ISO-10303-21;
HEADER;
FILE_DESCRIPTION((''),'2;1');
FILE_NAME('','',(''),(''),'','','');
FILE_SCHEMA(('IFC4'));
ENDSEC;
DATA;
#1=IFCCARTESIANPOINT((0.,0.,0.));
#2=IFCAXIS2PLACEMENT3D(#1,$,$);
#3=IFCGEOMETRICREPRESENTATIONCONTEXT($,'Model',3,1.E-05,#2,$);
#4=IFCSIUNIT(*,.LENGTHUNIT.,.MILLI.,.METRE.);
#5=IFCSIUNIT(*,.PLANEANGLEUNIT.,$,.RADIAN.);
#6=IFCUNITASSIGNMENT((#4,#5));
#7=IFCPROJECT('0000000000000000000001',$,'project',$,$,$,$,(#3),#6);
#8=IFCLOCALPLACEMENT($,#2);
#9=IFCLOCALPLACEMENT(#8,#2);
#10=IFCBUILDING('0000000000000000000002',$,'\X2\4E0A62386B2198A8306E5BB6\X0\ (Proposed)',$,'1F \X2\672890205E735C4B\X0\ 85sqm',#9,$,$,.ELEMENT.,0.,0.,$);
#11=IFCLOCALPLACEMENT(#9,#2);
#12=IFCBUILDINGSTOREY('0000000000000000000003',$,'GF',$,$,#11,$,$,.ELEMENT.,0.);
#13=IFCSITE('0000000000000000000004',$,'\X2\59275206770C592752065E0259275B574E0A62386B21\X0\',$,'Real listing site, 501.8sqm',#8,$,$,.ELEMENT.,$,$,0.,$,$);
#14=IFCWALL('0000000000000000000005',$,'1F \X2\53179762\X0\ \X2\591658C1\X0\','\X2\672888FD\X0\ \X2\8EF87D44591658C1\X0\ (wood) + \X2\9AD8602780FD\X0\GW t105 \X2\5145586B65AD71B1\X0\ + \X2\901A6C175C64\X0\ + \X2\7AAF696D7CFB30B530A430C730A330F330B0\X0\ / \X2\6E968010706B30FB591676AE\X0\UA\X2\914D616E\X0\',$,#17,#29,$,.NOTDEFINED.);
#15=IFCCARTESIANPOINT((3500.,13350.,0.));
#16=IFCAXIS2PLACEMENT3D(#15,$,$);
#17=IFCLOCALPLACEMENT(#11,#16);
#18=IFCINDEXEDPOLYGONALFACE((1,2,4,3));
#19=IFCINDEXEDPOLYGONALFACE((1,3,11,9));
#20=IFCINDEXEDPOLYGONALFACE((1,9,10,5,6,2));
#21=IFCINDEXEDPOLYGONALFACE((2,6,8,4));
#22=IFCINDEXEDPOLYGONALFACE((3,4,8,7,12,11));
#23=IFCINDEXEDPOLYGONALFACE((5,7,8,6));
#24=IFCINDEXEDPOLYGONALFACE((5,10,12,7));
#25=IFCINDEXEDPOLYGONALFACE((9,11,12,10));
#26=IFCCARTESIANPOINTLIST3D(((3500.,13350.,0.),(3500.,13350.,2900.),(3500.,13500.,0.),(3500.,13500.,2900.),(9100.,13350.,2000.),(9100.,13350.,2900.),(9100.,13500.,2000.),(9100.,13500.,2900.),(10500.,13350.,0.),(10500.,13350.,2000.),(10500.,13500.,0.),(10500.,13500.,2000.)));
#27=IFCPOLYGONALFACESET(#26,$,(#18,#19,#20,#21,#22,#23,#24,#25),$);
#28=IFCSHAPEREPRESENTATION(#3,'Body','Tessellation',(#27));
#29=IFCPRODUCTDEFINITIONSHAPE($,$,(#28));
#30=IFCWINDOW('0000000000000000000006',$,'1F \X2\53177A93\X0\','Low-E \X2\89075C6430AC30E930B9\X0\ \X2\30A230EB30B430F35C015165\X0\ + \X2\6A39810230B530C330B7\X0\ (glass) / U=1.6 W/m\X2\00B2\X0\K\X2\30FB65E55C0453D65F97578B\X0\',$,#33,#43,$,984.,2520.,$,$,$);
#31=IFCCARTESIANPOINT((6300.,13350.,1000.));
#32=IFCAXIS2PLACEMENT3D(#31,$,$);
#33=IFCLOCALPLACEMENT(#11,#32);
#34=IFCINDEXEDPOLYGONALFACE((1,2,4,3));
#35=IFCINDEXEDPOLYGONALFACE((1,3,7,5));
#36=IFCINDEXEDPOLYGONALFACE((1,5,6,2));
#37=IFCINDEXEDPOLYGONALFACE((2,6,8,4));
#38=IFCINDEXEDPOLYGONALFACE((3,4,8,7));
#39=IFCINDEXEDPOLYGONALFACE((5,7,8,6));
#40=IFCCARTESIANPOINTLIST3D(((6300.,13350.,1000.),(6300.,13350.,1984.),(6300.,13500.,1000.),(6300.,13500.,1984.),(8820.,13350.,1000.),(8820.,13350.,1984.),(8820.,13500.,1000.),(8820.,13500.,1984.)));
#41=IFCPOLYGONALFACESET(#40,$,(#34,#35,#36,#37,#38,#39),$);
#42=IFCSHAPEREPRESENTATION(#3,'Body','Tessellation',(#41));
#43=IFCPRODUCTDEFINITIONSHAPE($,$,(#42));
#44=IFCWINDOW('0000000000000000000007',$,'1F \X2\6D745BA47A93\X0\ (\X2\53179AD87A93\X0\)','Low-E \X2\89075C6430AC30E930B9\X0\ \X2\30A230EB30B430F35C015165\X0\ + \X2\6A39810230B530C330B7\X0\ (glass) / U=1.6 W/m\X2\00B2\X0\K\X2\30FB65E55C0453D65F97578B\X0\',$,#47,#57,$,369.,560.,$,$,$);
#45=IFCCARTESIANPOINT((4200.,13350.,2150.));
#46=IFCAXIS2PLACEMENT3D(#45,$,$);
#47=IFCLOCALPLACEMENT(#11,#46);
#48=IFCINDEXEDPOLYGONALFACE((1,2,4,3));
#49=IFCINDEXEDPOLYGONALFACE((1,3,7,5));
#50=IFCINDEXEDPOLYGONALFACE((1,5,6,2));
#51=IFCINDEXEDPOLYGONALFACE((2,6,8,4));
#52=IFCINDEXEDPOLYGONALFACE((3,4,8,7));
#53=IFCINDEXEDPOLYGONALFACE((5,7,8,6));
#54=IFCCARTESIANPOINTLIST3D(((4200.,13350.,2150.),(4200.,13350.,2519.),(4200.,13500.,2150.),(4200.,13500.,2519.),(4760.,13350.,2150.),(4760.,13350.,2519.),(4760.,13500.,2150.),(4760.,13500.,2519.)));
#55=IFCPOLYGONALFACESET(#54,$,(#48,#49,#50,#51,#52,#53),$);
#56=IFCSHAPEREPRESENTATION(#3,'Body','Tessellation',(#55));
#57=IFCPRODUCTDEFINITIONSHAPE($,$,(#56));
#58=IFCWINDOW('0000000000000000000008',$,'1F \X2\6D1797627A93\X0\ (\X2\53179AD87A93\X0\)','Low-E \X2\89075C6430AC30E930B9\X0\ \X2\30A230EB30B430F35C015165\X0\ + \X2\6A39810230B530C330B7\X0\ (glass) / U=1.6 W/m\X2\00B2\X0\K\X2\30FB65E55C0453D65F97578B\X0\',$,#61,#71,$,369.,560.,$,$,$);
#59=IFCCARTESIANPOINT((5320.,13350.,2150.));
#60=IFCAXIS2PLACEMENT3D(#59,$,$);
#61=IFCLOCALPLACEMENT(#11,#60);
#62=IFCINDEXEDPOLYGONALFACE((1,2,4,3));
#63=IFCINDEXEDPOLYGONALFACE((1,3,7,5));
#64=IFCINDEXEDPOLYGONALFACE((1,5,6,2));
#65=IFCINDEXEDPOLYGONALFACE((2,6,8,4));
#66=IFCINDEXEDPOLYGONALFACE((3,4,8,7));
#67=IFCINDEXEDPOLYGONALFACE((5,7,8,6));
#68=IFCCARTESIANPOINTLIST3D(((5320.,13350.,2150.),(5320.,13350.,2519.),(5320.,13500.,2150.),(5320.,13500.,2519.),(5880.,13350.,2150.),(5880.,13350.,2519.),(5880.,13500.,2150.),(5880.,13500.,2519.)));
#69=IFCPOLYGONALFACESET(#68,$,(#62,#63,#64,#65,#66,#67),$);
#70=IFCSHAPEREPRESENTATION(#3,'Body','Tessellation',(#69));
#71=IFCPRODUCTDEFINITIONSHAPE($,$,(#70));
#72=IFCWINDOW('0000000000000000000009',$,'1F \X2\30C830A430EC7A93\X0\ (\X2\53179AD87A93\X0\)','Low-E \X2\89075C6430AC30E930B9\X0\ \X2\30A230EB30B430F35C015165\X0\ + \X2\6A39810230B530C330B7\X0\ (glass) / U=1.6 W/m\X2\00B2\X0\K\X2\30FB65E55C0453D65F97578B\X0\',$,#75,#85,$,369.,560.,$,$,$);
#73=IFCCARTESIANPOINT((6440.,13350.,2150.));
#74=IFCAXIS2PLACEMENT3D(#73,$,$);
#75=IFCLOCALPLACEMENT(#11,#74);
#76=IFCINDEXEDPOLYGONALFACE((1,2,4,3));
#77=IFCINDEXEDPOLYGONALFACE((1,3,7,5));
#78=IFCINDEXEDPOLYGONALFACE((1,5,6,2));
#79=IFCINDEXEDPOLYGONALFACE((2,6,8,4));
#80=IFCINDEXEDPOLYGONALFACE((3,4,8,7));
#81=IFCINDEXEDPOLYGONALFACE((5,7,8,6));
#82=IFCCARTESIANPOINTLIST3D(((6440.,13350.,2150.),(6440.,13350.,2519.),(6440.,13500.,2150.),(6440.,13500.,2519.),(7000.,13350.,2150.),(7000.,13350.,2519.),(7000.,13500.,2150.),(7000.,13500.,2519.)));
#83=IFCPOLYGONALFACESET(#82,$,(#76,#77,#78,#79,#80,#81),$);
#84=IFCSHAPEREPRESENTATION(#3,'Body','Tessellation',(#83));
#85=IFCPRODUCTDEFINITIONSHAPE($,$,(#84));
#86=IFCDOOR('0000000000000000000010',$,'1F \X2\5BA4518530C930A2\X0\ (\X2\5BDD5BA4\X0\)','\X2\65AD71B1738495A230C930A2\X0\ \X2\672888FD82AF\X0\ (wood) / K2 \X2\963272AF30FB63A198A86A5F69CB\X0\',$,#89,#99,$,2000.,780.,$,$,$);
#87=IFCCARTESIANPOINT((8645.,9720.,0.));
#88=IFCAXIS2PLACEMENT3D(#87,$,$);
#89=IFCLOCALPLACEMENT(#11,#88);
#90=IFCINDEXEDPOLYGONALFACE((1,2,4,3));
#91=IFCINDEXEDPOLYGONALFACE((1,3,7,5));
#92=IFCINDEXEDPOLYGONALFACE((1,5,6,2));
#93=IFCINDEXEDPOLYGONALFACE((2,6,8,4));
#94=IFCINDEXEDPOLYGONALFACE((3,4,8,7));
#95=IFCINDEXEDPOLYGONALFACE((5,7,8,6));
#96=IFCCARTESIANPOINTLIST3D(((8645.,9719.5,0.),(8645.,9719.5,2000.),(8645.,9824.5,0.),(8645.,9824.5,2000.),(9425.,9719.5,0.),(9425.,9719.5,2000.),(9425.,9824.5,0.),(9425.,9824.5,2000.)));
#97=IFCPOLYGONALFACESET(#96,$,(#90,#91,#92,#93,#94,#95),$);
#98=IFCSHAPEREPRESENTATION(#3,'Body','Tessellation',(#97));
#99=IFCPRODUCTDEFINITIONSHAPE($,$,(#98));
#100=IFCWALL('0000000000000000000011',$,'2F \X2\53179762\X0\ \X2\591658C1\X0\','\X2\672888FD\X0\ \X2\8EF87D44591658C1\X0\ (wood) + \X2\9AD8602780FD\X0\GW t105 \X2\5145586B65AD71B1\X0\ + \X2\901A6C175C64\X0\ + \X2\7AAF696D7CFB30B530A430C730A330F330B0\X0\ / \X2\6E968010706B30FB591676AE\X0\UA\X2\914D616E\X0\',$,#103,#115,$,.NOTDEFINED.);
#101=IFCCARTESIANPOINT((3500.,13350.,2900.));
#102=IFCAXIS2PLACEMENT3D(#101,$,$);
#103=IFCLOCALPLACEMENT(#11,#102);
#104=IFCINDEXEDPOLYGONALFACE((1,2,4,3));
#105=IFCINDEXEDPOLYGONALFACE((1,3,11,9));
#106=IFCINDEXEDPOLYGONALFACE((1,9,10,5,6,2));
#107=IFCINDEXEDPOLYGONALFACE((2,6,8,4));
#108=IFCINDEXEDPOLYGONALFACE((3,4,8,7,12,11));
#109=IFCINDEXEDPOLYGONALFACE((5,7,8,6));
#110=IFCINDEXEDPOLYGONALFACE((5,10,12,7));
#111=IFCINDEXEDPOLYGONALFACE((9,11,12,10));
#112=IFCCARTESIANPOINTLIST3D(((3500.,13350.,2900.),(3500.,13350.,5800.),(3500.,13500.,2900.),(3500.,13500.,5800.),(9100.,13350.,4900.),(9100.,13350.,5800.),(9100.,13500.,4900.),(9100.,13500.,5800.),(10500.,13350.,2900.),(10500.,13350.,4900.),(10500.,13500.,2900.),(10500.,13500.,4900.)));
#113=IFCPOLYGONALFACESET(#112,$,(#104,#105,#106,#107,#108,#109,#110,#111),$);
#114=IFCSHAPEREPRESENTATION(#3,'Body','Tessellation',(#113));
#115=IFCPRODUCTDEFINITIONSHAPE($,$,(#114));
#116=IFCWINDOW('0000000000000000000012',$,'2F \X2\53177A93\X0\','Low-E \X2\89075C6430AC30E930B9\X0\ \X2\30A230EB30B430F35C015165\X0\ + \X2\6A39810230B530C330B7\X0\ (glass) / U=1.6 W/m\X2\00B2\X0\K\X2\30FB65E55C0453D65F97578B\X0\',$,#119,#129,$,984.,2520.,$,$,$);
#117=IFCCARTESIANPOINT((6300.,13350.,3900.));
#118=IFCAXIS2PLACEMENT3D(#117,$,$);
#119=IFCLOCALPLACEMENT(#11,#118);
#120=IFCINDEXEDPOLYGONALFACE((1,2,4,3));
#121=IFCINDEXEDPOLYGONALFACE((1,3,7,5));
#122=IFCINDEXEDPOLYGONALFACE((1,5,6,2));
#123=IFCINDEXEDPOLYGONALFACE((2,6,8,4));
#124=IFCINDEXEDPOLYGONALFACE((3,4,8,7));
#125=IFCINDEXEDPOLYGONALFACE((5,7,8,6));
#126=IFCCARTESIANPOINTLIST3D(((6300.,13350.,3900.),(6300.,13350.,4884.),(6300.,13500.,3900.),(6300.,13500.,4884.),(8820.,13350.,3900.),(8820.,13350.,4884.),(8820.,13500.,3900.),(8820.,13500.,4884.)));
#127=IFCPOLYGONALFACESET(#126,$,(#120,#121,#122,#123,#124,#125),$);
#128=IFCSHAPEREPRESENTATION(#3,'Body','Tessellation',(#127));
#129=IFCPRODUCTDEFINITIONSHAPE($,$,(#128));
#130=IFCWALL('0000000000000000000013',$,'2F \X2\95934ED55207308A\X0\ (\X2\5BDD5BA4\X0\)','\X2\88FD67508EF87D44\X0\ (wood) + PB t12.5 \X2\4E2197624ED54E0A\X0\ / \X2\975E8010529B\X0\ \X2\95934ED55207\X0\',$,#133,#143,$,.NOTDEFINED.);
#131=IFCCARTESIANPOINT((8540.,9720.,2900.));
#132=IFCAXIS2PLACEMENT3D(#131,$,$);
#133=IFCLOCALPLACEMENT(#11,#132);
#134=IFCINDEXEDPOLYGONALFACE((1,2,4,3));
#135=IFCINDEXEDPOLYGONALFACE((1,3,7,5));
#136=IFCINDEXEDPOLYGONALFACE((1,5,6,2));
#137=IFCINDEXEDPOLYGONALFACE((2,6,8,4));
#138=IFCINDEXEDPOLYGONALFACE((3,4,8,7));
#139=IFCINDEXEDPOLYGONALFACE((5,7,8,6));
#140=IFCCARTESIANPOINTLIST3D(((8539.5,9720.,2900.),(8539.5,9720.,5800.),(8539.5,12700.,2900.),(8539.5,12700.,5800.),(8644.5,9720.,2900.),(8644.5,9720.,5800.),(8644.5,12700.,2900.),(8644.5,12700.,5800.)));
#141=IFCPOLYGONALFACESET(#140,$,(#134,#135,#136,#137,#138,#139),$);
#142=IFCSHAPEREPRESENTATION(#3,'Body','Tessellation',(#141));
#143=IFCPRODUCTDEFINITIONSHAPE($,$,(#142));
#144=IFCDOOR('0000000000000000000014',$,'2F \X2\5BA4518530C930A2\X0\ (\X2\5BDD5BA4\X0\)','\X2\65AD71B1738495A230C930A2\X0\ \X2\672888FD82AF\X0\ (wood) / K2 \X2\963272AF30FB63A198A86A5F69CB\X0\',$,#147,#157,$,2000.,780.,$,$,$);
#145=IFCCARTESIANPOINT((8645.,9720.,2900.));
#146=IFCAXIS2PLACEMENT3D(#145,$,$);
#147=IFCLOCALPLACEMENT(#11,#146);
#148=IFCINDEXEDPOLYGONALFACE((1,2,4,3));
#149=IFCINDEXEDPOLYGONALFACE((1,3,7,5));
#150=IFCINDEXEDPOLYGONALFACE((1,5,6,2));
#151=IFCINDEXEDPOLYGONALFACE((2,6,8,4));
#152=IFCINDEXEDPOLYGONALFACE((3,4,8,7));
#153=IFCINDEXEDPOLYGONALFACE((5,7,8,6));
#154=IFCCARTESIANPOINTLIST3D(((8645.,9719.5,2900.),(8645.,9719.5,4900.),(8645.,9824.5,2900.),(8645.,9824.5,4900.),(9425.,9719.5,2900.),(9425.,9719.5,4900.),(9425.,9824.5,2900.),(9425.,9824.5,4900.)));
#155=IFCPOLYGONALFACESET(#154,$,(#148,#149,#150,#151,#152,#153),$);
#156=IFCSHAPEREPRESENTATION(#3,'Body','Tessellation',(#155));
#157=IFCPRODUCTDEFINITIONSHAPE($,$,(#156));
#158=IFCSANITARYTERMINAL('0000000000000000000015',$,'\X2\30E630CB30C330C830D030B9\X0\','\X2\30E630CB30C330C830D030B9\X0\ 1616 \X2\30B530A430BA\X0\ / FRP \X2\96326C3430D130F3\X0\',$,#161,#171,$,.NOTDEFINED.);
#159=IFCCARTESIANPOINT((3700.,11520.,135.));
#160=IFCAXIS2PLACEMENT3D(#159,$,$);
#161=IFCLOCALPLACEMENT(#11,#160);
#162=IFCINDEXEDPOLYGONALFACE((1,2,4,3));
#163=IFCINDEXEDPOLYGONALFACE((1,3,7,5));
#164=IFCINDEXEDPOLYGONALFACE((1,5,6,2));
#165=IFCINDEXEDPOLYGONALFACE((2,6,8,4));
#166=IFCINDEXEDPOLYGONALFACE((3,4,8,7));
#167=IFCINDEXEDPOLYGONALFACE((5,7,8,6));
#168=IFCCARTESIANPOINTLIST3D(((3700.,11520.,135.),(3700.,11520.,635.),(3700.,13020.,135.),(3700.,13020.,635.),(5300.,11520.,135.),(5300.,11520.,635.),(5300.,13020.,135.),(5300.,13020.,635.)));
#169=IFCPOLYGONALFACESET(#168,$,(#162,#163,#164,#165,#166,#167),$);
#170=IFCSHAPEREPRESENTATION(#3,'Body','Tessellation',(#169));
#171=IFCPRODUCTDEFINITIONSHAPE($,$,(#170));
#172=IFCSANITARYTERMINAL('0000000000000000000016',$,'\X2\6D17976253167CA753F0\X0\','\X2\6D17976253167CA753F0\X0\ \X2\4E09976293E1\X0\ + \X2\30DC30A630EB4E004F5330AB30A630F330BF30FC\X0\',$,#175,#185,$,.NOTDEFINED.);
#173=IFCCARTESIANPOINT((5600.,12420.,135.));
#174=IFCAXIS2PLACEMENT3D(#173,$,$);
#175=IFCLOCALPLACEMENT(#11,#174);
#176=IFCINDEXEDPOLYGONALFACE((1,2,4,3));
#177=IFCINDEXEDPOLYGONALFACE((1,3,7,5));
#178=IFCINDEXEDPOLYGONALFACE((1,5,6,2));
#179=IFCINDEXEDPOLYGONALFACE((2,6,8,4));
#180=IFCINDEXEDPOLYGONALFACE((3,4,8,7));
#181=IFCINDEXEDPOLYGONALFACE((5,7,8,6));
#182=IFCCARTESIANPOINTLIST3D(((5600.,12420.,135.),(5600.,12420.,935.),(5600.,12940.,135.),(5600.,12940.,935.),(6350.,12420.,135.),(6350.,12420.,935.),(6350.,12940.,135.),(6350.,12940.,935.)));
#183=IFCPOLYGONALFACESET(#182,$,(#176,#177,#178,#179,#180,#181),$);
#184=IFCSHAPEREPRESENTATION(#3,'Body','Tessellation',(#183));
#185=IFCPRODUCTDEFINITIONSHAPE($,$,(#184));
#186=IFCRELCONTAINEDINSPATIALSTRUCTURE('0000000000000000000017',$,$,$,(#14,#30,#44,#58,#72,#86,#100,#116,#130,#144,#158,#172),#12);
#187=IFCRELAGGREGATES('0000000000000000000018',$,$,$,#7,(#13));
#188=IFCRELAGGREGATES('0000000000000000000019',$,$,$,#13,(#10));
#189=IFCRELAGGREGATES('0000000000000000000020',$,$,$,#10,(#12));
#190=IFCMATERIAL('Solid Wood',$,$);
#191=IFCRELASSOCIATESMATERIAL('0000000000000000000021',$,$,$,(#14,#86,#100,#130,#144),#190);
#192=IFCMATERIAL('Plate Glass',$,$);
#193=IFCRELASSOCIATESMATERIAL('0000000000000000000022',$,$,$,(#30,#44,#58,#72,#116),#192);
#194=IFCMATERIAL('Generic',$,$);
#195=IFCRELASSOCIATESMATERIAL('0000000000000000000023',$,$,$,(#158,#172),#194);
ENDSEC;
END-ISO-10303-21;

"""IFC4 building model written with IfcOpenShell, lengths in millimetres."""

from ifc_helpers import new_model, si_unit, frame, frame_2d, origin, place, context, project, spatial, rectangle, extrude, material, element, fill, save


model = new_model("IFC4")

# Units and contexts
model_context = context("Model", 3, precision=1e-05, world=origin())
ifc_project = project(units=[si_unit("LENGTHUNIT", "METRE", prefix="MILLI"), si_unit("PLANEANGLEUNIT", "RADIAN")], contexts=[model_context])

# Site, building, storey
site_placement = place(None, origin())
site = spatial("IfcSite", under=ifc_project, at=site_placement, Name="大分県大分市大字上戸次", ObjectType="Real listing site, 501.8sqm", CompositionType="ELEMENT", RefElevation=0.0)
building_placement = place(site_placement, origin())
building = spatial("IfcBuilding", under=site, at=building_placement, Name="上戸次風の家 (Proposed)", ObjectType="1F 木造平屋 85sqm", CompositionType="ELEMENT", ElevationOfRefHeight=0.0, ElevationOfTerrain=0.0)
storey_placement = place(building_placement, origin())
storey = spatial("IfcBuildingStorey", under=building, at=storey_placement, Name="GF", CompositionType="ELEMENT", Elevation=0.0)

# Wall, openings, windows
ifc_material_1 = material(Name="Solid Wood")
wall_1_placement = place(storey_placement, frame((3500.0, 13350.0, 0.0)))
wall_1 = element("IfcWall", 1, at=wall_1_placement, inside=storey, material=ifc_material_1, Name="1F 北面 外壁", Description="木製 軸組外壁 (wood) + 高性能GW t105 充填断熱 + 通気層 + 窯業系サイディング / 準耐火・外皮UA配慮", PredefinedType="NOTDEFINED", context=model_context, shape_type="SweptSolid", body=[
    extrude(rectangle(XDim=7000.0, YDim=150.0, at=frame_2d((3500.0, 75.0))), frame((3500.0, 13350.0, 0.0)), (0.0, 0.0, 1.0), 2900.0),
])
opening_1_placement = place(storey_placement, frame((6300.0, 13350.0, 1000.0)))
opening_1 = element("IfcOpeningElement", 2, at=opening_1_placement, cuts=wall_1, PredefinedType="NOTDEFINED", context=model_context, shape_type="SweptSolid", body=[
    extrude(rectangle(XDim=2520.0, YDim=150.0, at=frame_2d((1260.0, 75.0))), frame((6300.0, 13350.0, 1000.0)), (0.0, 0.0, 1.0), 984.0),
])
opening_2_placement = place(storey_placement, frame((4200.0, 13350.0, 2150.0)))
opening_2 = element("IfcOpeningElement", 3, at=opening_2_placement, cuts=wall_1, PredefinedType="NOTDEFINED", context=model_context, shape_type="SweptSolid", body=[
    extrude(rectangle(XDim=560.0, YDim=150.0, at=frame_2d((280.0, 75.0))), frame((4200.0, 13350.0, 2150.0)), (0.0, 0.0, 1.0), 369.0),
])
opening_3_placement = place(storey_placement, frame((5320.0, 13350.0, 2150.0)))
opening_3 = element("IfcOpeningElement", 4, at=opening_3_placement, cuts=wall_1, PredefinedType="NOTDEFINED", context=model_context, shape_type="SweptSolid", body=[
    extrude(rectangle(XDim=560.0, YDim=150.0, at=frame_2d((280.0, 75.0))), frame((5320.0, 13350.0, 2150.0)), (0.0, 0.0, 1.0), 369.0),
])
opening_4_placement = place(storey_placement, frame((6440.0, 13350.0, 2150.0)))
opening_4 = element("IfcOpeningElement", 5, at=opening_4_placement, cuts=wall_1, PredefinedType="NOTDEFINED", context=model_context, shape_type="SweptSolid", body=[
    extrude(rectangle(XDim=560.0, YDim=150.0, at=frame_2d((280.0, 75.0))), frame((6440.0, 13350.0, 2150.0)), (0.0, 0.0, 1.0), 369.0),
])
ifc_material_2 = material(Name="Plate Glass")
window_1_placement = place(storey_placement, frame((6300.0, 13350.0, 1000.0)))
window_1 = element("IfcWindow", 6, at=window_1_placement, inside=storey, material=ifc_material_2, Name="1F 北窓", Description="Low-E 複層ガラス アルゴン封入 + 樹脂サッシ (glass) / U=1.6 W/m²K・日射取得型", OverallHeight=984.0, OverallWidth=2520.0, context=model_context, shape_type="SweptSolid", body=[
    extrude(rectangle(XDim=2520.0, YDim=150.0, at=frame_2d((1260.0, 75.0))), frame((6300.0, 13350.0, 1000.0)), (0.0, 0.0, 1.0), 984.0),
])
fill(opening_1, window_1)
window_2_placement = place(storey_placement, frame((4200.0, 13350.0, 2150.0)))
window_2 = element("IfcWindow", 7, at=window_2_placement, inside=storey, material=ifc_material_2, Name="1F 浴室窓 (北高窓)", Description="Low-E 複層ガラス アルゴン封入 + 樹脂サッシ (glass) / U=1.6 W/m²K・日射取得型", OverallHeight=369.0, OverallWidth=560.0, context=model_context, shape_type="SweptSolid", body=[
    extrude(rectangle(XDim=560.0, YDim=150.0, at=frame_2d((280.0, 75.0))), frame((4200.0, 13350.0, 2150.0)), (0.0, 0.0, 1.0), 369.0),
])
fill(opening_2, window_2)
window_3_placement = place(storey_placement, frame((5320.0, 13350.0, 2150.0)))
window_3 = element("IfcWindow", 8, at=window_3_placement, inside=storey, material=ifc_material_2, Name="1F 洗面窓 (北高窓)", Description="Low-E 複層ガラス アルゴン封入 + 樹脂サッシ (glass) / U=1.6 W/m²K・日射取得型", OverallHeight=369.0, OverallWidth=560.0, context=model_context, shape_type="SweptSolid", body=[
    extrude(rectangle(XDim=560.0, YDim=150.0, at=frame_2d((280.0, 75.0))), frame((5320.0, 13350.0, 2150.0)), (0.0, 0.0, 1.0), 369.0),
])
fill(opening_3, window_3)
window_4_placement = place(storey_placement, frame((6440.0, 13350.0, 2150.0)))
window_4 = element("IfcWindow", 9, at=window_4_placement, inside=storey, material=ifc_material_2, Name="1F トイレ窓 (北高窓)", Description="Low-E 複層ガラス アルゴン封入 + 樹脂サッシ (glass) / U=1.6 W/m²K・日射取得型", OverallHeight=369.0, OverallWidth=560.0, context=model_context, shape_type="SweptSolid", body=[
    extrude(rectangle(XDim=560.0, YDim=150.0, at=frame_2d((280.0, 75.0))), frame((6440.0, 13350.0, 2150.0)), (0.0, 0.0, 1.0), 369.0),
])
fill(opening_4, window_4)

# Door
door_1_placement = place(storey_placement, frame((8645.0, 9720.0, 0.0)))
element("IfcDoor", 10, at=door_1_placement, inside=storey, material=ifc_material_1, Name="1F 室内ドア (寝室)", Description="断熱玄関ドア 木製芯 (wood) / K2 防犯・採風機構", OverallHeight=2000.0, OverallWidth=780.0, context=model_context, shape_type="SweptSolid", body=[
    extrude(rectangle(XDim=780.0, YDim=105.0, at=frame_2d((390.0, 52.0))), frame((8645.0, 9720.0, 0.0)), (0.0, 0.0, 1.0), 2000.0),
])

# Wall, opening, window
wall_2_placement = place(storey_placement, frame((3500.0, 13350.0, 2900.0)))
wall_2 = element("IfcWall", 11, at=wall_2_placement, inside=storey, material=ifc_material_1, Name="2F 北面 外壁", Description="木製 軸組外壁 (wood) + 高性能GW t105 充填断熱 + 通気層 + 窯業系サイディング / 準耐火・外皮UA配慮", PredefinedType="NOTDEFINED", context=model_context, shape_type="SweptSolid", body=[
    extrude(rectangle(XDim=7000.0, YDim=150.0, at=frame_2d((3500.0, 75.0))), frame((3500.0, 13350.0, 2900.0)), (0.0, 0.0, 1.0), 2900.0),
])
opening_5_placement = place(storey_placement, frame((6300.0, 13350.0, 3900.0)))
opening_5 = element("IfcOpeningElement", 12, at=opening_5_placement, cuts=wall_2, PredefinedType="NOTDEFINED", context=model_context, shape_type="SweptSolid", body=[
    extrude(rectangle(XDim=2520.0, YDim=150.0, at=frame_2d((1260.0, 75.0))), frame((6300.0, 13350.0, 3900.0)), (0.0, 0.0, 1.0), 984.0),
])
window_5_placement = place(storey_placement, frame((6300.0, 13350.0, 3900.0)))
window_5 = element("IfcWindow", 13, at=window_5_placement, inside=storey, material=ifc_material_2, Name="2F 北窓", Description="Low-E 複層ガラス アルゴン封入 + 樹脂サッシ (glass) / U=1.6 W/m²K・日射取得型", OverallHeight=984.0, OverallWidth=2520.0, context=model_context, shape_type="SweptSolid", body=[
    extrude(rectangle(XDim=2520.0, YDim=150.0, at=frame_2d((1260.0, 75.0))), frame((6300.0, 13350.0, 3900.0)), (0.0, 0.0, 1.0), 984.0),
])
fill(opening_5, window_5)

# Wall
wall_3_placement = place(storey_placement, frame((8540.0, 9720.0, 2900.0)))
element("IfcWall", 14, at=wall_3_placement, inside=storey, material=ifc_material_1, Name="2F 間仕切り (寝室)", Description="製材軸組 (wood) + PB t12.5 両面仕上 / 非耐力 間仕切", PredefinedType="NOTDEFINED", context=model_context, shape_type="SweptSolid", body=[
    extrude(rectangle(XDim=105.0, YDim=2980.0, at=frame_2d((52.0, 1490.0))), frame((8540.0, 9720.0, 2900.0)), (0.0, 0.0, 1.0), 2900.0),
])

# Door
door_2_placement = place(storey_placement, frame((8645.0, 9720.0, 2900.0)))
element("IfcDoor", 15, at=door_2_placement, inside=storey, material=ifc_material_1, Name="2F 室内ドア (寝室)", Description="断熱玄関ドア 木製芯 (wood) / K2 防犯・採風機構", OverallHeight=2000.0, OverallWidth=780.0, context=model_context, shape_type="SweptSolid", body=[
    extrude(rectangle(XDim=780.0, YDim=105.0, at=frame_2d((390.0, 52.0))), frame((8645.0, 9720.0, 2900.0)), (0.0, 0.0, 1.0), 2000.0),
])

# Sanitary terminals
ifc_material_3 = material(Name="Generic")
sanitary_terminal_1_placement = place(storey_placement, frame((3700.0, 11520.0, 135.0)))
element("IfcSanitaryTerminal", 16, at=sanitary_terminal_1_placement, inside=storey, material=ifc_material_3, Name="ユニットバス", Description="ユニットバス 1616 サイズ / FRP 防水パン", PredefinedType="NOTDEFINED", context=model_context, shape_type="SweptSolid", body=[
    extrude(rectangle(XDim=1600.0, YDim=1500.0, at=frame_2d((800.0, 750.0))), frame((3700.0, 11520.0, 135.0)), (0.0, 0.0, 1.0), 500.0),
])
sanitary_terminal_2_placement = place(storey_placement, frame((5600.0, 12420.0, 135.0)))
element("IfcSanitaryTerminal", 17, at=sanitary_terminal_2_placement, inside=storey, material=ifc_material_3, Name="洗面化粧台", Description="洗面化粧台 三面鏡 + ボウル一体カウンター", PredefinedType="NOTDEFINED", context=model_context, shape_type="SweptSolid", body=[
    extrude(rectangle(XDim=750.0, YDim=520.0, at=frame_2d((375.0, 260.0))), frame((5600.0, 12420.0, 135.0)), (0.0, 0.0, 1.0), 800.0),
])

save(model, "model.ifc")
